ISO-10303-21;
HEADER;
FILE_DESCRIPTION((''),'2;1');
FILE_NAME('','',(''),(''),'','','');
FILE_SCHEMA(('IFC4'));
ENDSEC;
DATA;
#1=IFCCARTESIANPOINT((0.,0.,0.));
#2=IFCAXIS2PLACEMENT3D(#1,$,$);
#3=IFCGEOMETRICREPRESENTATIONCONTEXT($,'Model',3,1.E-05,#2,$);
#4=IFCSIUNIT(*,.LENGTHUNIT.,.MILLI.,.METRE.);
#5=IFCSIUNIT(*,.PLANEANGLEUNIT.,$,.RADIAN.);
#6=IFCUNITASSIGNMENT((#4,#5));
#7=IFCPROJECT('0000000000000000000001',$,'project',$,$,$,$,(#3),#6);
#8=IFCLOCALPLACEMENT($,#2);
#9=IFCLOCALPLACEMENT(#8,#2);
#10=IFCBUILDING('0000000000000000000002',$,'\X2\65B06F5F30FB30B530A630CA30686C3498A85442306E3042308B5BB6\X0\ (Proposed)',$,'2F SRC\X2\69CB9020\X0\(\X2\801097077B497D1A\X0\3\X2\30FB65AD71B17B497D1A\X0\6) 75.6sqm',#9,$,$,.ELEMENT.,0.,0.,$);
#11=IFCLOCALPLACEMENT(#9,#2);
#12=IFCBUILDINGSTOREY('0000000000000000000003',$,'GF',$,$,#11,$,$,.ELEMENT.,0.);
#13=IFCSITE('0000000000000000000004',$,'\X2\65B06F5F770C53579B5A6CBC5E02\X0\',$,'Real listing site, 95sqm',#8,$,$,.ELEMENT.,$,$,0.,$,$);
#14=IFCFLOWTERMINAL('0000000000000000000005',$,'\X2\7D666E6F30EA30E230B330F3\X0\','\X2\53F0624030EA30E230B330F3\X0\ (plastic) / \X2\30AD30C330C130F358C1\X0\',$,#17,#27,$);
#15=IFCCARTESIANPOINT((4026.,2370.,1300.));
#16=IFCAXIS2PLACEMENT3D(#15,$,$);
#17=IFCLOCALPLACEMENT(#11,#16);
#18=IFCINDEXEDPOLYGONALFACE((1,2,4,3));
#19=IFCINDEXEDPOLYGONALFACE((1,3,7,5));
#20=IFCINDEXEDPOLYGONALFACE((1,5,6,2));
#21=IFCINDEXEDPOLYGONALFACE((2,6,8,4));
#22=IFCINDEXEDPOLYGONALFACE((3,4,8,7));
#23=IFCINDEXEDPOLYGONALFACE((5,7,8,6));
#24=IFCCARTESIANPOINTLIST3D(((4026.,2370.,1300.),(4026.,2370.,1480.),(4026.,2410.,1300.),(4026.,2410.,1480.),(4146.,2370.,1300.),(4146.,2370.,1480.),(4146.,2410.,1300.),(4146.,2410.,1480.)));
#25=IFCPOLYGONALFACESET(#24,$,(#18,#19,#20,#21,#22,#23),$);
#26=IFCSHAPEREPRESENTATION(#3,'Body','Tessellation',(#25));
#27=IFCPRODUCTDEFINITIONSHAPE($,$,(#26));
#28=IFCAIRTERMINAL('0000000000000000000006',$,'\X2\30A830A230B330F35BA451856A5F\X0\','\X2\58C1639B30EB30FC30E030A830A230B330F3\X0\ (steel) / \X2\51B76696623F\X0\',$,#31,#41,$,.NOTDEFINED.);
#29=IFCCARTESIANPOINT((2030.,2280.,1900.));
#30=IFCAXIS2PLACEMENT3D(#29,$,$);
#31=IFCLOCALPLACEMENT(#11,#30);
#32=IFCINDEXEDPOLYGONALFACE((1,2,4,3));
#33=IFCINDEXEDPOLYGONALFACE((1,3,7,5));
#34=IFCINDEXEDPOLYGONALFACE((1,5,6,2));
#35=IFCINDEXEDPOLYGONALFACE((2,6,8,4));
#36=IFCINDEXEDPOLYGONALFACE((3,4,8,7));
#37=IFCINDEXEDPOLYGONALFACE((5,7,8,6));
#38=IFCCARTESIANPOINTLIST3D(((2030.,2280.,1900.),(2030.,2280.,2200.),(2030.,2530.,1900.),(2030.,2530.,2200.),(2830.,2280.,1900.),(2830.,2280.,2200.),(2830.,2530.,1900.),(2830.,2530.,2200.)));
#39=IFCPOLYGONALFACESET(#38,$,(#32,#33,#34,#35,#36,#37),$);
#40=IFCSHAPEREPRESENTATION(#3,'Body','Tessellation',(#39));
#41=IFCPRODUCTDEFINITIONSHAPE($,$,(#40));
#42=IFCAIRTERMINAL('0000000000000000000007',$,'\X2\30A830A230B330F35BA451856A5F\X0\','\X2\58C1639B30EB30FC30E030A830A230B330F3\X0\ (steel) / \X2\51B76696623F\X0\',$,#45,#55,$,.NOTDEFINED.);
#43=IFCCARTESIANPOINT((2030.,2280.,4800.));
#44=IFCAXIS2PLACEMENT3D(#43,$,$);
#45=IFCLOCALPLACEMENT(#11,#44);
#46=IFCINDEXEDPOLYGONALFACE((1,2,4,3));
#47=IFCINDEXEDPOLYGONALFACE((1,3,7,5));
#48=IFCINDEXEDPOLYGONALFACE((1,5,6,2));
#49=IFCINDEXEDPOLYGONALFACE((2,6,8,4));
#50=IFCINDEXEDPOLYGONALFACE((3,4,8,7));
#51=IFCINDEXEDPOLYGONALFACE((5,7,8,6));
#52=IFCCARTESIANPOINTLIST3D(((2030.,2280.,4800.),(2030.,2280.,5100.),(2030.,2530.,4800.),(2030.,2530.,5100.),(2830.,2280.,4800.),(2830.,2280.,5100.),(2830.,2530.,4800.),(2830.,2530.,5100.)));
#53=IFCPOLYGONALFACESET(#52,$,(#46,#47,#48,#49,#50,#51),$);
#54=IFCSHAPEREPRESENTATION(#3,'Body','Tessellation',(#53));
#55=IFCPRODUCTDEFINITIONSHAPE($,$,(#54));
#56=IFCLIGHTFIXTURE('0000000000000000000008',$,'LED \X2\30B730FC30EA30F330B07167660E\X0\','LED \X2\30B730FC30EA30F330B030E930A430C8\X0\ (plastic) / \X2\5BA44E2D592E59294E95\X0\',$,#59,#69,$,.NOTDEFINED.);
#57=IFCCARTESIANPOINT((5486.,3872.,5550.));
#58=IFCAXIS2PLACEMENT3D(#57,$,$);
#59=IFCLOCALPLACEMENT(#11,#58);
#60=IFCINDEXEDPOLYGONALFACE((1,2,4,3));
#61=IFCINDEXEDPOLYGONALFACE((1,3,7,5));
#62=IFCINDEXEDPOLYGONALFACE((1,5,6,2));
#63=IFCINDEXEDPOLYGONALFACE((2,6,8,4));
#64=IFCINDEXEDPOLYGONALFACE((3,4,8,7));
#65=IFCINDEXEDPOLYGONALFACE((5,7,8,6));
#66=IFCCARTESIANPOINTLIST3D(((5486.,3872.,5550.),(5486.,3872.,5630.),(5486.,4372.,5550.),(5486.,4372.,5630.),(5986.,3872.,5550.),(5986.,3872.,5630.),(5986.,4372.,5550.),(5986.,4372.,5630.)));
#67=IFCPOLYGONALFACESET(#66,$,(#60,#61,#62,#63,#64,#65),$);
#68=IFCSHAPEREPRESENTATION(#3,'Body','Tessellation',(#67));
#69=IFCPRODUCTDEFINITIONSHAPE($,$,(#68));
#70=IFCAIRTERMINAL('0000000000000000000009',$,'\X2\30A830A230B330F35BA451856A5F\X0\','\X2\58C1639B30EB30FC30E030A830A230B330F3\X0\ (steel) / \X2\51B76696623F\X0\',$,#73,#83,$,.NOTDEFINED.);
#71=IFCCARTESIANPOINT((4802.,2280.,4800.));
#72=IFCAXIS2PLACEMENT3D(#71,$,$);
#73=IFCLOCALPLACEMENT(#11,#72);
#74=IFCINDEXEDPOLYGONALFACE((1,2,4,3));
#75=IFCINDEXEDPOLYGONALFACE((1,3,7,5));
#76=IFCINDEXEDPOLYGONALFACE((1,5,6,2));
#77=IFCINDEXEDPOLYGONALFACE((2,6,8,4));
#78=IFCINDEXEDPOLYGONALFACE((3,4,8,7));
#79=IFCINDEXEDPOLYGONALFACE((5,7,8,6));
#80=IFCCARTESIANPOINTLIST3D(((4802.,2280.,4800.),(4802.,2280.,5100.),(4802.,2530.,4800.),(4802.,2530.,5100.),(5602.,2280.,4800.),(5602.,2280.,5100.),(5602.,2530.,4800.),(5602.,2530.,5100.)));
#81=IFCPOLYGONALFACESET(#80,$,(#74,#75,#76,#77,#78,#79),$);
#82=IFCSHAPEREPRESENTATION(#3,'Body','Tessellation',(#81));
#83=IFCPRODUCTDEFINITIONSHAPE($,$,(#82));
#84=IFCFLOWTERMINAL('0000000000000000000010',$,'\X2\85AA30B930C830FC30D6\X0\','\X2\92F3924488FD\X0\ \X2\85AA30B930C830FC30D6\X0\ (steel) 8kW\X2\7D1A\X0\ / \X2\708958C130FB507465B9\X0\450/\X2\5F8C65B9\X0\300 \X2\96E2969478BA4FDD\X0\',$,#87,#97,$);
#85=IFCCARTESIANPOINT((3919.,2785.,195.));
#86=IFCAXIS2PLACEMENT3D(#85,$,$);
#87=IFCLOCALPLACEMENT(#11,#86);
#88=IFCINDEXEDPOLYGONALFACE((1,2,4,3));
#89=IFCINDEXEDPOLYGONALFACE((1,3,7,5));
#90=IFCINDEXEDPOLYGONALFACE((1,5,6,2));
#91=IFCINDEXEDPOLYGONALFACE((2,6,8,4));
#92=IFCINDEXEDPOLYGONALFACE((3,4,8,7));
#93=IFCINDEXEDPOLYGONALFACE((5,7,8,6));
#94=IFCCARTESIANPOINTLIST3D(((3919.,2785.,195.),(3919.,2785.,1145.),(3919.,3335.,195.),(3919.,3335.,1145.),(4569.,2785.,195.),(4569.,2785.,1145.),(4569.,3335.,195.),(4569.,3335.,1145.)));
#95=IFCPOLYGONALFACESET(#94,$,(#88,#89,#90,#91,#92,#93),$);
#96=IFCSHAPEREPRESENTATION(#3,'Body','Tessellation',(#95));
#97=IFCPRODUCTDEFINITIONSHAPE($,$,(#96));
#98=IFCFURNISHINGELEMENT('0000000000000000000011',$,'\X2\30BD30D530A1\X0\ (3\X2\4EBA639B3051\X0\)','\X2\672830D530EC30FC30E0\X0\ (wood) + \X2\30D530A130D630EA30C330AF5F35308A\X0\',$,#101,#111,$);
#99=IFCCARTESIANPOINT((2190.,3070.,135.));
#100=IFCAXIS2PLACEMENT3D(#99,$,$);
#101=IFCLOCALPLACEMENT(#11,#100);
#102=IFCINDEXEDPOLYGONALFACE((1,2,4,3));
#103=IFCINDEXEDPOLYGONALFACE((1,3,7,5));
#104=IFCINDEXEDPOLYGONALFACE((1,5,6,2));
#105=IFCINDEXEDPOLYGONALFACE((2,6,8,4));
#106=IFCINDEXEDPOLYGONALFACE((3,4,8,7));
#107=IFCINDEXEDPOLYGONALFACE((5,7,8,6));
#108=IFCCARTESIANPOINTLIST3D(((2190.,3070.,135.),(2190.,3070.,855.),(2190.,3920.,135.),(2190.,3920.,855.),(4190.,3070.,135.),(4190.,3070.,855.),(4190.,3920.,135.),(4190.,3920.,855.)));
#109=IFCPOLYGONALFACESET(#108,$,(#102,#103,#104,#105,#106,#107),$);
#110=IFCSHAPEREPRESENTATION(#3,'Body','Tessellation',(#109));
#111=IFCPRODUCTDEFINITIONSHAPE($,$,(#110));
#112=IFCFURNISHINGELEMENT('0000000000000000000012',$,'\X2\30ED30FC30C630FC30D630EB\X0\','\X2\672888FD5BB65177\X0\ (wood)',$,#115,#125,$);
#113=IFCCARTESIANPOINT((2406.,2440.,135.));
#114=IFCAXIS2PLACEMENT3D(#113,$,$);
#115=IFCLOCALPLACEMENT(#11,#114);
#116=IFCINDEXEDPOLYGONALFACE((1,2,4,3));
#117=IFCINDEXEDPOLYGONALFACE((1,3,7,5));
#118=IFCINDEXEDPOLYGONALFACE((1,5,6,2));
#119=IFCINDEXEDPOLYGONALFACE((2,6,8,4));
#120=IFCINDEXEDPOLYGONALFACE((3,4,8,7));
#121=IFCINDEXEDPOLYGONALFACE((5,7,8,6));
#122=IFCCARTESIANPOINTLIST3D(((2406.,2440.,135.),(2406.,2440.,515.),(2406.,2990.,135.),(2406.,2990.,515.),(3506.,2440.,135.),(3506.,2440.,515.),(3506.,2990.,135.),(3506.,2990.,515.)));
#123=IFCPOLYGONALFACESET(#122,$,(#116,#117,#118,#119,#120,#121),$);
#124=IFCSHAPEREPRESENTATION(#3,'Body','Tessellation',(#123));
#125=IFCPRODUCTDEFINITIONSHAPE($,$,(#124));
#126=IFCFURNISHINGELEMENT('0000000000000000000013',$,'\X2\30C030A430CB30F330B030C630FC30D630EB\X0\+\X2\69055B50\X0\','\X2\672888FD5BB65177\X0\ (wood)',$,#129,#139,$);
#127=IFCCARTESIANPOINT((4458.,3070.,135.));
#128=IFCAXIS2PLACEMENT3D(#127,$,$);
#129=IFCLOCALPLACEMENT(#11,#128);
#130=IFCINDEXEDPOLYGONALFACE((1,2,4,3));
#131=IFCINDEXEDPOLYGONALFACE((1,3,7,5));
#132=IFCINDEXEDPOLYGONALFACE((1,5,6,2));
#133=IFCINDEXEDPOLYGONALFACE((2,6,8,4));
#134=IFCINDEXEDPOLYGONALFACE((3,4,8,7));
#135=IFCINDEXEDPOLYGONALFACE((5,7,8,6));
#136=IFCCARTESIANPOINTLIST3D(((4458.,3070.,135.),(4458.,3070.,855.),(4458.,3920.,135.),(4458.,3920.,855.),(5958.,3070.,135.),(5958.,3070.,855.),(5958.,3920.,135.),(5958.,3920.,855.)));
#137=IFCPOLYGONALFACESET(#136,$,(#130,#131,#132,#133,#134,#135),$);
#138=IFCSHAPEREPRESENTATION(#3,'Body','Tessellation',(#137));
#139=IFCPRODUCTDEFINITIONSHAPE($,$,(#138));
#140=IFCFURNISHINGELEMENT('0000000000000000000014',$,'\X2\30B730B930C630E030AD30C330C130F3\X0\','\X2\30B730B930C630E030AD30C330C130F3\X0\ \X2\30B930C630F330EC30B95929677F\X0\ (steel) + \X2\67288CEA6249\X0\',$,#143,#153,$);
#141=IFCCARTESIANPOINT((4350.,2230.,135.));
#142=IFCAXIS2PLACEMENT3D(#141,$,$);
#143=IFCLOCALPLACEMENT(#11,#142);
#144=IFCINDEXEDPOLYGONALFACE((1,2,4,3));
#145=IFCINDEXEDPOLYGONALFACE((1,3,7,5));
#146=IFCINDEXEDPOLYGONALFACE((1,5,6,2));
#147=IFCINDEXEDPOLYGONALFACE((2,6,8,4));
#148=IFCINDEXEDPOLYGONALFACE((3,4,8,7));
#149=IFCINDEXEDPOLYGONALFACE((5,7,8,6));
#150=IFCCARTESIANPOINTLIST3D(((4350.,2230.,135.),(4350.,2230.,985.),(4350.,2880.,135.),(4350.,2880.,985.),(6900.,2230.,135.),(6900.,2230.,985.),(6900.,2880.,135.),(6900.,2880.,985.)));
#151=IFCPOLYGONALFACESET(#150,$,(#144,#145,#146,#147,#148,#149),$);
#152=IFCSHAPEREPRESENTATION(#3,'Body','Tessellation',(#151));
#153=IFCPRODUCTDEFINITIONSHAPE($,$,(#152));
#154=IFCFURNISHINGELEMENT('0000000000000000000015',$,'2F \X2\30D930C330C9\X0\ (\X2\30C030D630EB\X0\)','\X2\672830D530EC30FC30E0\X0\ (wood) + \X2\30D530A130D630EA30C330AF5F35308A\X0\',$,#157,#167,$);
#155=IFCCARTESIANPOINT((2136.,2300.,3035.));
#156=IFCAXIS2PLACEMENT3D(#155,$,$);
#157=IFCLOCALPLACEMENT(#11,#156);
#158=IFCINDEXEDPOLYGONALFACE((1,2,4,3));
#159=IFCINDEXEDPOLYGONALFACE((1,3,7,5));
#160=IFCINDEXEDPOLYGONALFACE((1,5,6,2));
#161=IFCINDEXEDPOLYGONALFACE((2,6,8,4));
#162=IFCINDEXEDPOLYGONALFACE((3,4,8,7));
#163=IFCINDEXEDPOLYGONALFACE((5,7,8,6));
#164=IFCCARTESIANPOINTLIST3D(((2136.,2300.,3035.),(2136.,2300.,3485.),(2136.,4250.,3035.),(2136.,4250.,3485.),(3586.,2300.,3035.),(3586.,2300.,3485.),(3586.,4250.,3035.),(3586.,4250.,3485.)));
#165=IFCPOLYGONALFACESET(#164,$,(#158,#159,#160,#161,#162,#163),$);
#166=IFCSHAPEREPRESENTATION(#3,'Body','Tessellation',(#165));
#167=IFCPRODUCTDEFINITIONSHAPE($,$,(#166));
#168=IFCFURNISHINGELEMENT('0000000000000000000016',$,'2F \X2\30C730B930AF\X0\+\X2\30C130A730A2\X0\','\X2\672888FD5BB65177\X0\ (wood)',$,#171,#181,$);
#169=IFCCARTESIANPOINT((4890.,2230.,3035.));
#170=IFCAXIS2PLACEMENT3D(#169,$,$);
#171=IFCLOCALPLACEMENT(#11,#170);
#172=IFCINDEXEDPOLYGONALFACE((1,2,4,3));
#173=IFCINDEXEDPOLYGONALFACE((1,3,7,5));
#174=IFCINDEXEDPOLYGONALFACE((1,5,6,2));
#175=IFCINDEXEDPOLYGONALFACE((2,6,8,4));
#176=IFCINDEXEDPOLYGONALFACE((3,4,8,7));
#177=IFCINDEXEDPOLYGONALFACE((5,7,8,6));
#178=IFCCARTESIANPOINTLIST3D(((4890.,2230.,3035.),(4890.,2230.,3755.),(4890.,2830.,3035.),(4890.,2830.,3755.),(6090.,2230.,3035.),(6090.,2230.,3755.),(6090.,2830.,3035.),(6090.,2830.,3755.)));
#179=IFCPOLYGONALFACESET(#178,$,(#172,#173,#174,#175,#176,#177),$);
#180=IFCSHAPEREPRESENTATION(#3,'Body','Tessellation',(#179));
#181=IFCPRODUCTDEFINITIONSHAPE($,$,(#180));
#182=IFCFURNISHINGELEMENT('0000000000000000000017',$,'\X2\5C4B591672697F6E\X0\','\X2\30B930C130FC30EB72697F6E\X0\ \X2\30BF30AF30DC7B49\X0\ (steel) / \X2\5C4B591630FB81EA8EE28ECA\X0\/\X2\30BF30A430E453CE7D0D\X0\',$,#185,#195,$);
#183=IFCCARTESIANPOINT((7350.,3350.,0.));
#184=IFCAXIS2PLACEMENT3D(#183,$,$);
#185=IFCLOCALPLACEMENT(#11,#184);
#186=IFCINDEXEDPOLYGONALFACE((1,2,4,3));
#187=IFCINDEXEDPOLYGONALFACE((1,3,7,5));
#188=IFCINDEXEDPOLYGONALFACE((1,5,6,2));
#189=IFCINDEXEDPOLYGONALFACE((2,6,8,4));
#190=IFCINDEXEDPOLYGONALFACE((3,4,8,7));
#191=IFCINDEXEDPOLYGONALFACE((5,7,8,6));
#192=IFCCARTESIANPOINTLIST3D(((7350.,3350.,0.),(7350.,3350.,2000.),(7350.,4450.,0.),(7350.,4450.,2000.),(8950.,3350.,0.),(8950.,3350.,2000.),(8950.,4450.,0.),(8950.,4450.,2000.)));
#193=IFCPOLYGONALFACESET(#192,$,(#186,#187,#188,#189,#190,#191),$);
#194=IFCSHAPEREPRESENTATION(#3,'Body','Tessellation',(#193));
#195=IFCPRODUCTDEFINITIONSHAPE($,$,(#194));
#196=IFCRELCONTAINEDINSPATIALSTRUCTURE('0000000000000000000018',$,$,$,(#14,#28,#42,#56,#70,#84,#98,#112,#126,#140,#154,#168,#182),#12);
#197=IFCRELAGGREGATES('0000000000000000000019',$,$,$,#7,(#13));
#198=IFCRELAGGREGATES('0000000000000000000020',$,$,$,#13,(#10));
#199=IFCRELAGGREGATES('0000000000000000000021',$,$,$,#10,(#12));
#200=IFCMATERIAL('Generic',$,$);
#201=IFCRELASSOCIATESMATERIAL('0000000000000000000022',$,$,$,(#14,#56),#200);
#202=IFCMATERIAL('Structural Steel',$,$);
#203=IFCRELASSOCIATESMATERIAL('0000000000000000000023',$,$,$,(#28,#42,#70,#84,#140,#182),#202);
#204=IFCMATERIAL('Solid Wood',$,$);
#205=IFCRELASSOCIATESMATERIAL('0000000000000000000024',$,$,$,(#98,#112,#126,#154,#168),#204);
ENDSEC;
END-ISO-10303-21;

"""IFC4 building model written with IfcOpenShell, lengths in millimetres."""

from ifc_helpers import new_model, si_unit, frame, frame_2d, origin, place, context, project, spatial, rectangle, extrude, material, element, save


model = new_model("IFC4")

# Units and contexts
model_context = context("Model", 3, precision=1e-05, world=origin())
ifc_project = project(units=[si_unit("LENGTHUNIT", "METRE", prefix="MILLI"), si_unit("PLANEANGLEUNIT", "RADIAN")], contexts=[model_context])

# Site, building, storey
site_placement = place(None, origin())
site = spatial("IfcSite", under=ifc_project, at=site_placement, Name="新潟県南魚沼市", ObjectType="Real listing site, 95sqm", CompositionType="ELEMENT", RefElevation=0.0)
building_placement = place(site_placement, origin())
building = spatial("IfcBuilding", under=site, at=building_placement, Name="新潟・サウナと水風呂のある家 (Proposed)", ObjectType="2F SRC構造(耐震等級3・断熱等級6) 75.6sqm", CompositionType="ELEMENT", ElevationOfRefHeight=0.0, ElevationOfTerrain=0.0)
storey_placement = place(building_placement, origin())
storey = spatial("IfcBuildingStorey", under=building, at=storey_placement, Name="GF", CompositionType="ELEMENT", Elevation=0.0)

# Shared definitions
ifc_material_1 = material(Name="Solid Wood")

# Shared definitions
ifc_material_2 = material(Name="Structural Steel")

# Shared definitions
ifc_material_3 = material(Name="Generic")

# Flow terminal
flow_terminal_1_placement = place(storey_placement, frame((4026.0, 2370.0, 1300.0)))
element("IfcFlowTerminal", 1, at=flow_terminal_1_placement, inside=storey, material=ifc_material_3, Name="給湯リモコン", Description="台所リモコン (plastic) / キッチン壁", context=model_context, shape_type="SweptSolid", body=[
    extrude(rectangle(XDim=120.0, YDim=40.0, at=frame_2d((60.0, 20.0))), frame((4026.0, 2370.0, 1300.0)), (0.0, 0.0, 1.0), 180.0),
])

# Air terminals
air_terminal_1_placement = place(storey_placement, frame((2030.0, 2280.0, 1900.0)))
element("IfcAirTerminal", 2, at=air_terminal_1_placement, inside=storey, material=ifc_material_2, Name="エアコン室内機", Description="壁掛ルームエアコン (steel) / 冷暖房", PredefinedType="NOTDEFINED", context=model_context, shape_type="SweptSolid", body=[
    extrude(rectangle(XDim=800.0, YDim=250.0, at=frame_2d((400.0, 125.0))), frame((2030.0, 2280.0, 1900.0)), (0.0, 0.0, 1.0), 300.0),
])
air_terminal_2_placement = place(storey_placement, frame((2030.0, 2280.0, 4800.0)))
element("IfcAirTerminal", 3, at=air_terminal_2_placement, inside=storey, material=ifc_material_2, Name="エアコン室内機", Description="壁掛ルームエアコン (steel) / 冷暖房", PredefinedType="NOTDEFINED", context=model_context, shape_type="SweptSolid", body=[
    extrude(rectangle(XDim=800.0, YDim=250.0, at=frame_2d((400.0, 125.0))), frame((2030.0, 2280.0, 4800.0)), (0.0, 0.0, 1.0), 300.0),
])

# Light fixture
light_fixture_placement = place(storey_placement, frame((5486.0, 3872.0, 5550.0)))
element("IfcLightFixture", 4, at=light_fixture_placement, inside=storey, material=ifc_material_3, Name="LED シーリング照明", Description="LED シーリングライト (plastic) / 室中央天井", PredefinedType="NOTDEFINED", context=model_context, shape_type="SweptSolid", body=[
    extrude(rectangle(XDim=500.0, YDim=500.0, at=frame_2d((250.0, 250.0))), frame((5486.0, 3872.0, 5550.0)), (0.0, 0.0, 1.0), 80.0),
])

# Air terminal
air_terminal_3_placement = place(storey_placement, frame((4802.0, 2280.0, 4800.0)))
element("IfcAirTerminal", 5, at=air_terminal_3_placement, inside=storey, material=ifc_material_2, Name="エアコン室内機", Description="壁掛ルームエアコン (steel) / 冷暖房", PredefinedType="NOTDEFINED", context=model_context, shape_type="SweptSolid", body=[
    extrude(rectangle(XDim=800.0, YDim=250.0, at=frame_2d((400.0, 125.0))), frame((4802.0, 2280.0, 4800.0)), (0.0, 0.0, 1.0), 300.0),
])

# Flow terminal
flow_terminal_2_placement = place(storey_placement, frame((3919.0, 2785.0, 195.0)))
element("IfcFlowTerminal", 6, at=flow_terminal_2_placement, inside=storey, material=ifc_material_2, Name="薪ストーブ", Description="鋳鉄製 薪ストーブ (steel) 8kW級 / 炉壁・側方450/後方300 離隔確保", context=model_context, shape_type="SweptSolid", body=[
    extrude(rectangle(XDim=650.0, YDim=550.0, at=frame_2d((325.0, 275.0))), frame((3919.0, 2785.0, 195.0)), (0.0, 0.0, 1.0), 950.0),
])

# Furnishing elements
furnishing_1_placement = place(storey_placement, frame((2190.0, 3070.0, 135.0)))
element("IfcFurnishingElement", 7, at=furnishing_1_placement, inside=storey, material=ifc_material_1, Name="ソファ (3人掛け)", Description="木フレーム (wood) + ファブリック張り", context=model_context, shape_type="SweptSolid", body=[
    extrude(rectangle(XDim=2000.0, YDim=850.0, at=frame_2d((1000.0, 425.0))), frame((2190.0, 3070.0, 135.0)), (0.0, 0.0, 1.0), 720.0),
])
furnishing_2_placement = place(storey_placement, frame((2406.0, 2440.0, 135.0)))
element("IfcFurnishingElement", 8, at=furnishing_2_placement, inside=storey, material=ifc_material_1, Name="ローテーブル", Description="木製家具 (wood)", context=model_context, shape_type="SweptSolid", body=[
    extrude(rectangle(XDim=1100.0, YDim=550.0, at=frame_2d((550.0, 275.0))), frame((2406.0, 2440.0, 135.0)), (0.0, 0.0, 1.0), 380.0),
])
furnishing_3_placement = place(storey_placement, frame((4458.0, 3070.0, 135.0)))
element("IfcFurnishingElement", 9, at=furnishing_3_placement, inside=storey, material=ifc_material_1, Name="ダイニングテーブル+椅子", Description="木製家具 (wood)", context=model_context, shape_type="SweptSolid", body=[
    extrude(rectangle(XDim=1500.0, YDim=850.0, at=frame_2d((750.0, 425.0))), frame((4458.0, 3070.0, 135.0)), (0.0, 0.0, 1.0), 720.0),
])
furnishing_4_placement = place(storey_placement, frame((4350.0, 2230.0, 135.0)))
element("IfcFurnishingElement", 10, at=furnishing_4_placement, inside=storey, material=ifc_material_2, Name="システムキッチン", Description="システムキッチン ステンレス天板 (steel) + 木質扉", context=model_context, shape_type="SweptSolid", body=[
    extrude(rectangle(XDim=2550.0, YDim=650.0, at=frame_2d((1275.0, 325.0))), frame((4350.0, 2230.0, 135.0)), (0.0, 0.0, 1.0), 850.0),
])
furnishing_5_placement = place(storey_placement, frame((2136.0, 2300.0, 3035.0)))
element("IfcFurnishingElement", 11, at=furnishing_5_placement, inside=storey, material=ifc_material_1, Name="2F ベッド (ダブル)", Description="木フレーム (wood) + ファブリック張り", context=model_context, shape_type="SweptSolid", body=[
    extrude(rectangle(XDim=1450.0, YDim=1950.0, at=frame_2d((725.0, 975.0))), frame((2136.0, 2300.0, 3035.0)), (0.0, 0.0, 1.0), 450.0),
])
furnishing_6_placement = place(storey_placement, frame((4890.0, 2230.0, 3035.0)))
element("IfcFurnishingElement", 12, at=furnishing_6_placement, inside=storey, material=ifc_material_1, Name="2F デスク+チェア", Description="木製家具 (wood)", context=model_context, shape_type="SweptSolid", body=[
    extrude(rectangle(XDim=1200.0, YDim=600.0, at=frame_2d((600.0, 300.0))), frame((4890.0, 2230.0, 3035.0)), (0.0, 0.0, 1.0), 720.0),
])
furnishing_7_placement = place(storey_placement, frame((7350.0, 3350.0, 0.0)))
element("IfcFurnishingElement", 13, at=furnishing_7_placement, inside=storey, material=ifc_material_2, Name="屋外物置", Description="スチール物置 タクボ等 (steel) / 屋外・自転車/タイヤ収納", context=model_context, shape_type="SweptSolid", body=[
    extrude(rectangle(XDim=1600.0, YDim=1100.0, at=frame_2d((800.0, 550.0))), frame((7350.0, 3350.0, 0.0)), (0.0, 0.0, 1.0), 2000.0),
])

save(model, "model.ifc")
